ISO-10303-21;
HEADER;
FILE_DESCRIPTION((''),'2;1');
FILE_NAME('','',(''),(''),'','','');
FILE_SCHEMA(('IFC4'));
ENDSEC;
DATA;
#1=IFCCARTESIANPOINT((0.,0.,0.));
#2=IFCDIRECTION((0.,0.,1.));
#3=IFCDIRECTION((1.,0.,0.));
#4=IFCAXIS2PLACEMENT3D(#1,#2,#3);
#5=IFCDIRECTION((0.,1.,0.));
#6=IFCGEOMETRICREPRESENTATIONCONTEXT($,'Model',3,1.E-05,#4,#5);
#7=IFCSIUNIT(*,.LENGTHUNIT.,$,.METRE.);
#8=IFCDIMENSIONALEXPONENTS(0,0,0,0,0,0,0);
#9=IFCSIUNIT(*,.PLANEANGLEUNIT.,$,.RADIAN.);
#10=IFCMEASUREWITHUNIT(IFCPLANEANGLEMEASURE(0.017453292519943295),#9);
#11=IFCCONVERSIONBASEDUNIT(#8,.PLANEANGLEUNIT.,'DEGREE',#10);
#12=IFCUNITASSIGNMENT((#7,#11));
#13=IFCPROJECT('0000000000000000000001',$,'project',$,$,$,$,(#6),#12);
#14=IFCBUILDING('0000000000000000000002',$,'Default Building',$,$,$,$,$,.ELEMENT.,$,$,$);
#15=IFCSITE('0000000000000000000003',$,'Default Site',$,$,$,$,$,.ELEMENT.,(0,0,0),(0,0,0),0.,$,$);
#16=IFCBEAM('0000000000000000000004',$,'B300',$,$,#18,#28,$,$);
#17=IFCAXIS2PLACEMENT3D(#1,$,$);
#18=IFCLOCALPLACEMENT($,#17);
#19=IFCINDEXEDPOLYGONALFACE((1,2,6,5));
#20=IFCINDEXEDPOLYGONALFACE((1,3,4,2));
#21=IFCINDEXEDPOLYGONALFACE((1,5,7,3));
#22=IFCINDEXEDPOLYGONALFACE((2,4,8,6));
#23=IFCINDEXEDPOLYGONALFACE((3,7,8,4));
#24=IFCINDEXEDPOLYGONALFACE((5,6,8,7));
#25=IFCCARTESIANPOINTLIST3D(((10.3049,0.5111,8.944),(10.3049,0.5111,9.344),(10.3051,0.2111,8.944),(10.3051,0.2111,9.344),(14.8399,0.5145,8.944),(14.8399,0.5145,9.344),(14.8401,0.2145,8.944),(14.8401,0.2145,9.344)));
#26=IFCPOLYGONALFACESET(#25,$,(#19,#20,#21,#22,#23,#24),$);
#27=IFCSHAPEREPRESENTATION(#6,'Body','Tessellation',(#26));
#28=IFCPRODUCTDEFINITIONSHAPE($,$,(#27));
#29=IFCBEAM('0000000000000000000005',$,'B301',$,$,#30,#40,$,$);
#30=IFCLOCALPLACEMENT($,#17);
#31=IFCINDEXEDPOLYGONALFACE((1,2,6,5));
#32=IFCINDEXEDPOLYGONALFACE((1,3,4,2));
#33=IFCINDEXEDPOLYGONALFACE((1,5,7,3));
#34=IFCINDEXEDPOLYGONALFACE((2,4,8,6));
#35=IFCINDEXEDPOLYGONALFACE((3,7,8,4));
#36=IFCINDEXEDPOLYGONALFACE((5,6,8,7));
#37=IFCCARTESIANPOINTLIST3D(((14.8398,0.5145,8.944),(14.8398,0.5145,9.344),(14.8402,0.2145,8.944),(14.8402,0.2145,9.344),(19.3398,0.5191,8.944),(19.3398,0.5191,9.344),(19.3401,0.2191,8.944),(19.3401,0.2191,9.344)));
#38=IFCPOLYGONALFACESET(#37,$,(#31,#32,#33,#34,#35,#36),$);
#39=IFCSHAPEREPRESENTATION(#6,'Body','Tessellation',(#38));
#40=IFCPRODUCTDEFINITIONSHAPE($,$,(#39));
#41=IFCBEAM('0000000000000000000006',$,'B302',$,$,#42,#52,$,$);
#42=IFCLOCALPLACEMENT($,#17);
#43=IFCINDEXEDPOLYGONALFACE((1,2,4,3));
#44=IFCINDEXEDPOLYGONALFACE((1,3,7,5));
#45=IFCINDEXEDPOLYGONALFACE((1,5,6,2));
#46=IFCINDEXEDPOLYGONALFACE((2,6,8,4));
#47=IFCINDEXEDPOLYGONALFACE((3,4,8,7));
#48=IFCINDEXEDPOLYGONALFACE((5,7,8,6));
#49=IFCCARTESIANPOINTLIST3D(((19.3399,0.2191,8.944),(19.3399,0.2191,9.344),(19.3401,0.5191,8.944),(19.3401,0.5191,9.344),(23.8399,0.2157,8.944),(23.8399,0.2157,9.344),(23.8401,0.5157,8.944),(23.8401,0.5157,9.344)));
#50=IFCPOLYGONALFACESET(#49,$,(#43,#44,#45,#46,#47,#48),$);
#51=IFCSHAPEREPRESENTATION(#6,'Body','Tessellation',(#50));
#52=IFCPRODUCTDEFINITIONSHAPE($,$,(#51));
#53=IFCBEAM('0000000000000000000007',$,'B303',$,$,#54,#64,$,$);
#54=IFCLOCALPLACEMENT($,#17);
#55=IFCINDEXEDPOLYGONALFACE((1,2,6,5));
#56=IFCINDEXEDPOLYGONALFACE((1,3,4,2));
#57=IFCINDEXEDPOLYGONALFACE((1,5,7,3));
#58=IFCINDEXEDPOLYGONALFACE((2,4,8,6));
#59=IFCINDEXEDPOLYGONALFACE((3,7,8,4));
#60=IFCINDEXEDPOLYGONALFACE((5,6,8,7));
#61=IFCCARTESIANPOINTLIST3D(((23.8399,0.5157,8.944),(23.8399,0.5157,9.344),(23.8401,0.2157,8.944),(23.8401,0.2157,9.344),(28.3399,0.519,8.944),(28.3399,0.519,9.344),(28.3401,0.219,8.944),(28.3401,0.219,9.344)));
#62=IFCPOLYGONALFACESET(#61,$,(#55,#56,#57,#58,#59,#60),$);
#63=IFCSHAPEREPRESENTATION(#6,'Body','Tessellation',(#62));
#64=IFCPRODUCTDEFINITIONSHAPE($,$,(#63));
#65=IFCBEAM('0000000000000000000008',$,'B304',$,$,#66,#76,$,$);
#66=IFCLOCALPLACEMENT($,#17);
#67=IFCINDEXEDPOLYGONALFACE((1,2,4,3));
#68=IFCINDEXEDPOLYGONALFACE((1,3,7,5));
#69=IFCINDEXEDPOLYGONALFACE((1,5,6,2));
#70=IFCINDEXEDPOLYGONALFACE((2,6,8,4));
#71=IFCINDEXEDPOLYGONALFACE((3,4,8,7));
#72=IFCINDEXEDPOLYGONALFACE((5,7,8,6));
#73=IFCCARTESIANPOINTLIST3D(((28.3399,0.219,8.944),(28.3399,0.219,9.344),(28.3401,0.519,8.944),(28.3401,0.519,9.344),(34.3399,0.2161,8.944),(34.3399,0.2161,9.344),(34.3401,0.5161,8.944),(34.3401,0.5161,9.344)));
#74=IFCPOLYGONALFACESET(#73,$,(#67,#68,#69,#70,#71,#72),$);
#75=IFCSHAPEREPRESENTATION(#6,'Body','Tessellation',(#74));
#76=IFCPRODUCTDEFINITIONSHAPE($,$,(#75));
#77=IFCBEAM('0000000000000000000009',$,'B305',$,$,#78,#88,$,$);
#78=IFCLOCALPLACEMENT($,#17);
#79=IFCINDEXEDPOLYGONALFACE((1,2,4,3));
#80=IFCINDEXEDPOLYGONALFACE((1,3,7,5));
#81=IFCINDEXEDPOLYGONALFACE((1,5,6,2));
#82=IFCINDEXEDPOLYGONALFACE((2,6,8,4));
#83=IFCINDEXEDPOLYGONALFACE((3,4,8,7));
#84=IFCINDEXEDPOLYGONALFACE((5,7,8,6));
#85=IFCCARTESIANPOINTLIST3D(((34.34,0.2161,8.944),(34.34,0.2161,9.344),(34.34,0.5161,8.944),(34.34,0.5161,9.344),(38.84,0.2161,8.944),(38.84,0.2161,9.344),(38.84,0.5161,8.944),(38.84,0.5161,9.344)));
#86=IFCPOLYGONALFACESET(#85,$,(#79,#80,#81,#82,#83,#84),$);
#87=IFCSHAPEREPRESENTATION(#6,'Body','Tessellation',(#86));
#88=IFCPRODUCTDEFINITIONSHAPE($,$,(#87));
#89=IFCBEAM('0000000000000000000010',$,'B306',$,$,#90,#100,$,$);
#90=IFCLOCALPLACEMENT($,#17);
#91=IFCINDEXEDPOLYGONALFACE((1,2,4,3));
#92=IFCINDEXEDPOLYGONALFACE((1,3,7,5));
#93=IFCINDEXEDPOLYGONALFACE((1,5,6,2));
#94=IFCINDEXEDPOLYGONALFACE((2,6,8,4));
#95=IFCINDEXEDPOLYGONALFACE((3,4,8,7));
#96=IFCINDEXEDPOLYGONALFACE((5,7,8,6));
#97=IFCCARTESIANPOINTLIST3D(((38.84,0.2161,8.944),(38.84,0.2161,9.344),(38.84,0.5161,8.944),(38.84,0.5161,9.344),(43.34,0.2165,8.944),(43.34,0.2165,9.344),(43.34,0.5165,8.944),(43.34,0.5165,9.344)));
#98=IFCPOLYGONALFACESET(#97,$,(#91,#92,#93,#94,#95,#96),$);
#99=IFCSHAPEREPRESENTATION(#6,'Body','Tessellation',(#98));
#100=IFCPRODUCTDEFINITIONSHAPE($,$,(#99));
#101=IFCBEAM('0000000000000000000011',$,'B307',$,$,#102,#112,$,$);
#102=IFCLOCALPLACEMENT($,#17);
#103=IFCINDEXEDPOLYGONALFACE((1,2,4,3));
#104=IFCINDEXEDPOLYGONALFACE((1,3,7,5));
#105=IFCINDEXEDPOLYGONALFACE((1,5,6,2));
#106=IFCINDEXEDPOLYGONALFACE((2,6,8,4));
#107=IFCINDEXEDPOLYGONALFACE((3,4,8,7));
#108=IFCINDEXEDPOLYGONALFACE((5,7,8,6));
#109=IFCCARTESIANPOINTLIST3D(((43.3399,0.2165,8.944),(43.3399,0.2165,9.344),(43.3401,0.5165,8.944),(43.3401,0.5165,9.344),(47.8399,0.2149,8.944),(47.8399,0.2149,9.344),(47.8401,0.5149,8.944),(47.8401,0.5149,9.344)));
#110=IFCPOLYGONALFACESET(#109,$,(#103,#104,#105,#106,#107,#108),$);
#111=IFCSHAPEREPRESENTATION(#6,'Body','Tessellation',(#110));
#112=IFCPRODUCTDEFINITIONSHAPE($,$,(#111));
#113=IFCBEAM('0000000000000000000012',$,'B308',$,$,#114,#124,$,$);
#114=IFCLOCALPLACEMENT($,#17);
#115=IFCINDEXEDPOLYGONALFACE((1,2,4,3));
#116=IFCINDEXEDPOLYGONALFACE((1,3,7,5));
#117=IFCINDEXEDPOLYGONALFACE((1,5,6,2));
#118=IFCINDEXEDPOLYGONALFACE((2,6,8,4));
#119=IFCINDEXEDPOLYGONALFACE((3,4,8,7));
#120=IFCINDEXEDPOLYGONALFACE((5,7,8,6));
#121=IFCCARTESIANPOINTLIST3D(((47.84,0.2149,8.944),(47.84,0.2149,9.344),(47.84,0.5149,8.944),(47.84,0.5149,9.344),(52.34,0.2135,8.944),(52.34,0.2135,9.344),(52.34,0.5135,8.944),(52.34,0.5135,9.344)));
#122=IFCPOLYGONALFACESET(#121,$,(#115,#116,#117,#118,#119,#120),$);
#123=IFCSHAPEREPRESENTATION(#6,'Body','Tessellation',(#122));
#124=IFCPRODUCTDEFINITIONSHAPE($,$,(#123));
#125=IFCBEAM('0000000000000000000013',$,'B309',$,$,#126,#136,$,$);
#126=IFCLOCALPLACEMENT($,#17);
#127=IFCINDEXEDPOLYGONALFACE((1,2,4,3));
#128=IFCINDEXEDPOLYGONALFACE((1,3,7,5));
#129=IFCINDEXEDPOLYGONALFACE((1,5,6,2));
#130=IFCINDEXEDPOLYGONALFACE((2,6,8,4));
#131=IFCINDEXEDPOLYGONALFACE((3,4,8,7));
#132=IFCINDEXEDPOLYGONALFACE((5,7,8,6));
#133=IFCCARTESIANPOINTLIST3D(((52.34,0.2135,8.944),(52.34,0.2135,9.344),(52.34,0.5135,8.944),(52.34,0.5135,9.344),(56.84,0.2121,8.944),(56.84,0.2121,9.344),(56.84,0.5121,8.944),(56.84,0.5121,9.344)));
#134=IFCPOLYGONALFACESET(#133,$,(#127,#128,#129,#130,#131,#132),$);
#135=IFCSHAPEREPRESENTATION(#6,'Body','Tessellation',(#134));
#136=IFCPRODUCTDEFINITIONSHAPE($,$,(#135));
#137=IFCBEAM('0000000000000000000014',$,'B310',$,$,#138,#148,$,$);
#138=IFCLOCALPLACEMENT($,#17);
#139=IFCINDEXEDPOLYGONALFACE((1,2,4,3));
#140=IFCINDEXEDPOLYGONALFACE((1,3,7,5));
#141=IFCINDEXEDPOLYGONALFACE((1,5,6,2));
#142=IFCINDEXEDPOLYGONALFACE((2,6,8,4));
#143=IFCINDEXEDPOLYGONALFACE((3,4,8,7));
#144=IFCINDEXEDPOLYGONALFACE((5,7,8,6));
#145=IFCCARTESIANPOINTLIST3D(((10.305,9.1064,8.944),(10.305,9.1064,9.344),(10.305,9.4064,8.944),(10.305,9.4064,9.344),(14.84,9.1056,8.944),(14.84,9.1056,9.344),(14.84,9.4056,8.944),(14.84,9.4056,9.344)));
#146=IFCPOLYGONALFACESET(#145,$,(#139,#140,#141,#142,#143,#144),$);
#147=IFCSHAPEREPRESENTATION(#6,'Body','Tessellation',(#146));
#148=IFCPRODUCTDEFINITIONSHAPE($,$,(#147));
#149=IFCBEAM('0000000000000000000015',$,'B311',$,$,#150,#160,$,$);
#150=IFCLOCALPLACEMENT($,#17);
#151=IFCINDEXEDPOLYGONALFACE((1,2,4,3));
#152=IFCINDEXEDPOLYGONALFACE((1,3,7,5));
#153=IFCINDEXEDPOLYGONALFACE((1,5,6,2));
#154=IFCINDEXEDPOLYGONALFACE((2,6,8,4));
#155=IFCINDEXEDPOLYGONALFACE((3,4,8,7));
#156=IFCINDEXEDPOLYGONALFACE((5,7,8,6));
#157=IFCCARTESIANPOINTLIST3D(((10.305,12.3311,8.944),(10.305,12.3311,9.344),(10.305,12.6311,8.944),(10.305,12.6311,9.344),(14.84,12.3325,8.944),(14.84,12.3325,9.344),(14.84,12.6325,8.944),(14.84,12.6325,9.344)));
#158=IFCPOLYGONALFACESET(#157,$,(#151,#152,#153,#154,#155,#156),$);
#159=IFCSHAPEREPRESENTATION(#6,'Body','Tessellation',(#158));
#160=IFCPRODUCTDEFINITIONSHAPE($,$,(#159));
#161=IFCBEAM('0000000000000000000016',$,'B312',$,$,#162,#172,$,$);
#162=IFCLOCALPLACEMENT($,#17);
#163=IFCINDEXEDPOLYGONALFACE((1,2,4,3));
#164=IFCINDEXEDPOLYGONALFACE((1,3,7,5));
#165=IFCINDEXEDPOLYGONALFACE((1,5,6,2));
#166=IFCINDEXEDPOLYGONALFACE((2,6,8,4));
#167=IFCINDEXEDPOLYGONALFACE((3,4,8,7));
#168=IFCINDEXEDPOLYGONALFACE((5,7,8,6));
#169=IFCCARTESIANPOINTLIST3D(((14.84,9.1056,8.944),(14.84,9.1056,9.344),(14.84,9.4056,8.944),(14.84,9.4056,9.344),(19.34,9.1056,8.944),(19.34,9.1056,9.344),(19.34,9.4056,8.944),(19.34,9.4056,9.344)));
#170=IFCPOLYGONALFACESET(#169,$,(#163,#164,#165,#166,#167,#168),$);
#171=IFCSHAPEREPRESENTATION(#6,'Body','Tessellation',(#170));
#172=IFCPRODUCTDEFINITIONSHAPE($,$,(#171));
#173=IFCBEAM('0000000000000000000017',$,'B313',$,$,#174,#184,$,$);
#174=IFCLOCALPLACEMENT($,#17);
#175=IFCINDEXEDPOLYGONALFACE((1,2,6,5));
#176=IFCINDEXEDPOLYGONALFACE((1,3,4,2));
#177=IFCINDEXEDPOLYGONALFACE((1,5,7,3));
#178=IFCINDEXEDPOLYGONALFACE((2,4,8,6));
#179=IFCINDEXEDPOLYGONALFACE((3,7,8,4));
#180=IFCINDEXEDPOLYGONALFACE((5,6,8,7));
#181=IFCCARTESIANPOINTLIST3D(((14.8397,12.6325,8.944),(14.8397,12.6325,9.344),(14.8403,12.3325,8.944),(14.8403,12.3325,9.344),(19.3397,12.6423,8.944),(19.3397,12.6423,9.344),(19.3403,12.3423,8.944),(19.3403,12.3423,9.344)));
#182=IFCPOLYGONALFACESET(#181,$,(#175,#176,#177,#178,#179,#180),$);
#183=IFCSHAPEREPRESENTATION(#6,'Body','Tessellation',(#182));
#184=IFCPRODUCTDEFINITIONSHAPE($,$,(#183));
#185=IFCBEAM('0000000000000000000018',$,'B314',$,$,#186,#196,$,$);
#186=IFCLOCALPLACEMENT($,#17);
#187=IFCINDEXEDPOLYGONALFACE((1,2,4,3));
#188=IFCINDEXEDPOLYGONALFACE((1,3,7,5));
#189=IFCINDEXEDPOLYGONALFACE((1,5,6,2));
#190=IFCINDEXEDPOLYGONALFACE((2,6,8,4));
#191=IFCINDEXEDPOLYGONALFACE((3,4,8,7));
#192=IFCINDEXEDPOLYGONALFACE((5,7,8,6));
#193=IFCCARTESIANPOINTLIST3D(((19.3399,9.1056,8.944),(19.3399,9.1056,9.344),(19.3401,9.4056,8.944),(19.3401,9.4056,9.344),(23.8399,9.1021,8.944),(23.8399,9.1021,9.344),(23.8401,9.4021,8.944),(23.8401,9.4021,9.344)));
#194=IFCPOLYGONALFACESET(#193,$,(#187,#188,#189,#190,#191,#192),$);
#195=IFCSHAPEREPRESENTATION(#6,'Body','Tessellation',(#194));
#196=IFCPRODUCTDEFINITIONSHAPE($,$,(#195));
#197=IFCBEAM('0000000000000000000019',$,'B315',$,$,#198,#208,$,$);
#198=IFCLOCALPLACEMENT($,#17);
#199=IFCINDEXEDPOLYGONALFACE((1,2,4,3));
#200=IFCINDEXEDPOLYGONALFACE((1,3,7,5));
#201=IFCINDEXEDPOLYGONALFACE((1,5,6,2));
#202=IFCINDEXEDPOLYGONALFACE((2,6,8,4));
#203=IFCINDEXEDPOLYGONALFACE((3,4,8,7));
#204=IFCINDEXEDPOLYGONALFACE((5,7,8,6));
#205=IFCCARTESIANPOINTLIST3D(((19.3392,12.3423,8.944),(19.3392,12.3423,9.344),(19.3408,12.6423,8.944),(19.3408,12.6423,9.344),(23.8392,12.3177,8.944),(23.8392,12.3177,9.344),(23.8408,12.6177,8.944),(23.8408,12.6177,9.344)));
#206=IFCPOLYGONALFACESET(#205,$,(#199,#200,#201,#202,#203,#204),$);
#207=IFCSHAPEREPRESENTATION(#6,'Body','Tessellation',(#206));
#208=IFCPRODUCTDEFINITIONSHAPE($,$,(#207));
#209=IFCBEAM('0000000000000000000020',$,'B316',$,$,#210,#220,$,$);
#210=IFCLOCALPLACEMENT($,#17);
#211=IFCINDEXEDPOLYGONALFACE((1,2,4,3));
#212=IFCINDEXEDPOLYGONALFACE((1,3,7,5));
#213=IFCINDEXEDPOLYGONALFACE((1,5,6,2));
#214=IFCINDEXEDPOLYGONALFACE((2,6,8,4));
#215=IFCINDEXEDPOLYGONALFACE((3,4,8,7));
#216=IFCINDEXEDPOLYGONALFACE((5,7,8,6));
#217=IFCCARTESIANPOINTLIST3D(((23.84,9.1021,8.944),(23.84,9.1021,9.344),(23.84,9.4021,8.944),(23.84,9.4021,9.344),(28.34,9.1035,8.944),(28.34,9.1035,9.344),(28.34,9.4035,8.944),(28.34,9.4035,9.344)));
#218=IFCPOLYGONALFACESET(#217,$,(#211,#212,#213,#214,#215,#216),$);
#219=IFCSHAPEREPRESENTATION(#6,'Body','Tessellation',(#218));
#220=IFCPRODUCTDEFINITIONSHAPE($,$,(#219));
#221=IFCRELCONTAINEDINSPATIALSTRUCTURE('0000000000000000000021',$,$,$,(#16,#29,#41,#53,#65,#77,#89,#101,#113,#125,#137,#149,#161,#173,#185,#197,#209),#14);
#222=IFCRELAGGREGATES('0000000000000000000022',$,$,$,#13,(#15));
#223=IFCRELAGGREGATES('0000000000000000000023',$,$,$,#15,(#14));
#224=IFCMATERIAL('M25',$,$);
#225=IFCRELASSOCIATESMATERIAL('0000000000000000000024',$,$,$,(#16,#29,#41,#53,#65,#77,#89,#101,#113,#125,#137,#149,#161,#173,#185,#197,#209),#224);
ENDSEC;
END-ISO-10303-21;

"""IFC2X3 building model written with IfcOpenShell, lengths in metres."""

from ifc_helpers import new_model, entity, si_unit, converted_unit, direction, frame, frame_2d, origin_with_axes, place, context, project, spatial, rectangle, extrude, material, element, save


model = new_model("IFC2X3")

# Units and contexts
model_context = context("Model", 3, precision=1e-05, world=origin_with_axes(), true_north=direction((0.0, 1.0, 0.0)))
ifc_project = project(units=[si_unit("LENGTHUNIT", "METRE"), converted_unit("PLANEANGLEUNIT", "DEGREE", entity("IfcPlaneAngleMeasure", 0.017453292519943295), si_unit("PLANEANGLEUNIT", "RADIAN"), dimensions=[0, 0, 0, 0, 0, 0, 0])], contexts=[model_context])

# Site, building
site = spatial("IfcSite", under=ifc_project, Name="Default Site", CompositionType="ELEMENT", RefLatitude=(0, 0, 0), RefLongitude=(0, 0, 0), RefElevation=0.0)
building = spatial("IfcBuilding", under=site, Name="Default Building", CompositionType="ELEMENT")

# Beams
ifc_material = material(Name="M25")
placement = place(None, origin_with_axes())
element("IfcBeam", 1, at=placement, inside=building, material=ifc_material, Name="B300", context=model_context, shape_type="SweptSolid", body=[
    extrude(rectangle(XDim=0.3, YDim=0.4, at=frame_2d((0.0, 0.0), x_axis=(0.0, 1.0, 0.0))), frame((10.305, 0.3611, 9.144), z_axis=(1.0, 0.000762, 0.0), x_axis=(0.0, 0.0, -1.0)), (0.0, 0.0, 1.0), 4.535),
])
element("IfcBeam", 2, at=placement, inside=building, material=ifc_material, Name="B301", context=model_context, shape_type="SweptSolid", body=[
    extrude(rectangle(XDim=0.3, YDim=0.4, at=frame_2d((0.0, 0.0), x_axis=(0.0, 1.0, 0.0))), frame((14.84, 0.3645, 9.144), z_axis=(0.999999, 0.00101, 0.0), x_axis=(0.0, 0.0, -1.0)), (0.0, 0.0, 1.0), 4.5),
])
element("IfcBeam", 3, at=placement, inside=building, material=ifc_material, Name="B302", context=model_context, shape_type="SweptSolid", body=[
    extrude(rectangle(XDim=0.3, YDim=0.4, at=frame_2d((0.0, 0.0), x_axis=(0.0, 1.0, 0.0))), frame((19.34, 0.3691, 9.144), z_axis=(1.0, -0.000757, 0.0), x_axis=(0.0, 0.0, -1.0)), (0.0, 0.0, 1.0), 4.5),
])
element("IfcBeam", 4, at=placement, inside=building, material=ifc_material, Name="B303", context=model_context, shape_type="SweptSolid", body=[
    extrude(rectangle(XDim=0.3, YDim=0.4, at=frame_2d((0.0, 0.0), x_axis=(0.0, 1.0, 0.0))), frame((23.84, 0.3657, 9.144), z_axis=(1.0, 0.00075, 0.0), x_axis=(0.0, 0.0, -1.0)), (0.0, 0.0, 1.0), 4.5),
])
element("IfcBeam", 5, at=placement, inside=building, material=ifc_material, Name="B304", context=model_context, shape_type="SweptSolid", body=[
    extrude(rectangle(XDim=0.3, YDim=0.4, at=frame_2d((0.0, 0.0), x_axis=(0.0, 1.0, 0.0))), frame((28.34, 0.369, 9.144), z_axis=(1.0, -0.000487, 0.0), x_axis=(0.0, 0.0, -1.0)), (0.0, 0.0, 1.0), 6.0),
])
element("IfcBeam", 6, at=placement, inside=building, material=ifc_material, Name="B305", context=model_context, shape_type="SweptSolid", body=[
    extrude(rectangle(XDim=0.3, YDim=0.4, at=frame_2d((0.0, 0.0), x_axis=(0.0, 1.0, 0.0))), frame((34.34, 0.3661, 9.144), z_axis=(1.0, 0.000003, 0.0), x_axis=(0.0, 0.0, -1.0)), (0.0, 0.0, 1.0), 4.5),
])
element("IfcBeam", 7, at=placement, inside=building, material=ifc_material, Name="B306", context=model_context, shape_type="SweptSolid", body=[
    extrude(rectangle(XDim=0.3, YDim=0.4, at=frame_2d((0.0, 0.0), x_axis=(0.0, 1.0, 0.0))), frame((38.84, 0.3661, 9.144), z_axis=(1.0, 0.000077, 0.0), x_axis=(0.0, 0.0, -1.0)), (0.0, 0.0, 1.0), 4.5),
])
element("IfcBeam", 8, at=placement, inside=building, material=ifc_material, Name="B307", context=model_context, shape_type="SweptSolid", body=[
    extrude(rectangle(XDim=0.3, YDim=0.4, at=frame_2d((0.0, 0.0), x_axis=(0.0, 1.0, 0.0))), frame((43.34, 0.3665, 9.144), z_axis=(1.0, -0.000358, 0.0), x_axis=(0.0, 0.0, -1.0)), (0.0, 0.0, 1.0), 4.5),
])
element("IfcBeam", 9, at=placement, inside=building, material=ifc_material, Name="B308", context=model_context, shape_type="SweptSolid", body=[
    extrude(rectangle(XDim=0.3, YDim=0.4, at=frame_2d((0.0, 0.0), x_axis=(0.0, 1.0, 0.0))), frame((47.84, 0.3649, 9.144), z_axis=(1.0, -0.000297, 0.0), x_axis=(0.0, 0.0, -1.0)), (0.0, 0.0, 1.0), 4.5),
])
element("IfcBeam", 10, at=placement, inside=building, material=ifc_material, Name="B309", context=model_context, shape_type="SweptSolid", body=[
    extrude(rectangle(XDim=0.3, YDim=0.4, at=frame_2d((0.0, 0.0), x_axis=(0.0, 1.0, 0.0))), frame((52.34, 0.3635, 9.144), z_axis=(1.0, -0.000311, 0.0), x_axis=(0.0, 0.0, -1.0)), (0.0, 0.0, 1.0), 4.5),
])
element("IfcBeam", 11, at=placement, inside=building, material=ifc_material, Name="B310", context=model_context, shape_type="SweptSolid", body=[
    extrude(rectangle(XDim=0.3, YDim=0.4, at=frame_2d((0.0, 0.0), x_axis=(0.0, 1.0, 0.0))), frame((10.305, 9.2564, 9.144), z_axis=(1.0, -0.000182, 0.0), x_axis=(0.0, 0.0, -1.0)), (0.0, 0.0, 1.0), 4.535),
])
element("IfcBeam", 12, at=placement, inside=building, material=ifc_material, Name="B311", context=model_context, shape_type="SweptSolid", body=[
    extrude(rectangle(XDim=0.3, YDim=0.4, at=frame_2d((0.0, 0.0), x_axis=(0.0, 1.0, 0.0))), frame((10.305, 12.4811, 9.144), z_axis=(1.0, 0.000301, 0.0), x_axis=(0.0, 0.0, -1.0)), (0.0, 0.0, 1.0), 4.535),
])
element("IfcBeam", 13, at=placement, inside=building, material=ifc_material, Name="B312", context=model_context, shape_type="SweptSolid", body=[
    extrude(rectangle(XDim=0.3, YDim=0.4, at=frame_2d((0.0, 0.0), x_axis=(0.0, 1.0, 0.0))), frame((14.84, 9.2556, 9.144), z_axis=(1.0, 0.000013, 0.0), x_axis=(0.0, 0.0, -1.0)), (0.0, 0.0, 1.0), 4.5),
])
element("IfcBeam", 14, at=placement, inside=building, material=ifc_material, Name="B313", context=model_context, shape_type="SweptSolid", body=[
    extrude(rectangle(XDim=0.3, YDim=0.4, at=frame_2d((0.0, 0.0), x_axis=(0.0, 1.0, 0.0))), frame((14.84, 12.4825, 9.144), z_axis=(0.999998, 0.002176, 0.0), x_axis=(0.0, 0.0, -1.0)), (0.0, 0.0, 1.0), 4.5),
])
element("IfcBeam", 15, at=placement, inside=building, material=ifc_material, Name="B314", context=model_context, shape_type="SweptSolid", body=[
    extrude(rectangle(XDim=0.3, YDim=0.4, at=frame_2d((0.0, 0.0), x_axis=(0.0, 1.0, 0.0))), frame((19.34, 9.2556, 9.144), z_axis=(1.0, -0.000779, 0.0), x_axis=(0.0, 0.0, -1.0)), (0.0, 0.0, 1.0), 4.5),
])
element("IfcBeam", 16, at=placement, inside=building, material=ifc_material, Name="B315", context=model_context, shape_type="SweptSolid", body=[
    extrude(rectangle(XDim=0.3, YDim=0.4, at=frame_2d((0.0, 0.0), x_axis=(0.0, 1.0, 0.0))), frame((19.34, 12.4923, 9.144), z_axis=(0.999985, -0.005463, 0.0), x_axis=(0.0, 0.0, -1.0)), (0.0, 0.0, 1.0), 4.5001),
])
element("IfcBeam", 17, at=placement, inside=building, material=ifc_material, Name="B316", context=model_context, shape_type="SweptSolid", body=[
    extrude(rectangle(XDim=0.3, YDim=0.4, at=frame_2d((0.0, 0.0), x_axis=(0.0, 1.0, 0.0))), frame((23.84, 9.2521, 9.144), z_axis=(1.0, 0.000307, 0.0), x_axis=(0.0, 0.0, -1.0)), (0.0, 0.0, 1.0), 4.5),
])

save(model, "model.ifc")
